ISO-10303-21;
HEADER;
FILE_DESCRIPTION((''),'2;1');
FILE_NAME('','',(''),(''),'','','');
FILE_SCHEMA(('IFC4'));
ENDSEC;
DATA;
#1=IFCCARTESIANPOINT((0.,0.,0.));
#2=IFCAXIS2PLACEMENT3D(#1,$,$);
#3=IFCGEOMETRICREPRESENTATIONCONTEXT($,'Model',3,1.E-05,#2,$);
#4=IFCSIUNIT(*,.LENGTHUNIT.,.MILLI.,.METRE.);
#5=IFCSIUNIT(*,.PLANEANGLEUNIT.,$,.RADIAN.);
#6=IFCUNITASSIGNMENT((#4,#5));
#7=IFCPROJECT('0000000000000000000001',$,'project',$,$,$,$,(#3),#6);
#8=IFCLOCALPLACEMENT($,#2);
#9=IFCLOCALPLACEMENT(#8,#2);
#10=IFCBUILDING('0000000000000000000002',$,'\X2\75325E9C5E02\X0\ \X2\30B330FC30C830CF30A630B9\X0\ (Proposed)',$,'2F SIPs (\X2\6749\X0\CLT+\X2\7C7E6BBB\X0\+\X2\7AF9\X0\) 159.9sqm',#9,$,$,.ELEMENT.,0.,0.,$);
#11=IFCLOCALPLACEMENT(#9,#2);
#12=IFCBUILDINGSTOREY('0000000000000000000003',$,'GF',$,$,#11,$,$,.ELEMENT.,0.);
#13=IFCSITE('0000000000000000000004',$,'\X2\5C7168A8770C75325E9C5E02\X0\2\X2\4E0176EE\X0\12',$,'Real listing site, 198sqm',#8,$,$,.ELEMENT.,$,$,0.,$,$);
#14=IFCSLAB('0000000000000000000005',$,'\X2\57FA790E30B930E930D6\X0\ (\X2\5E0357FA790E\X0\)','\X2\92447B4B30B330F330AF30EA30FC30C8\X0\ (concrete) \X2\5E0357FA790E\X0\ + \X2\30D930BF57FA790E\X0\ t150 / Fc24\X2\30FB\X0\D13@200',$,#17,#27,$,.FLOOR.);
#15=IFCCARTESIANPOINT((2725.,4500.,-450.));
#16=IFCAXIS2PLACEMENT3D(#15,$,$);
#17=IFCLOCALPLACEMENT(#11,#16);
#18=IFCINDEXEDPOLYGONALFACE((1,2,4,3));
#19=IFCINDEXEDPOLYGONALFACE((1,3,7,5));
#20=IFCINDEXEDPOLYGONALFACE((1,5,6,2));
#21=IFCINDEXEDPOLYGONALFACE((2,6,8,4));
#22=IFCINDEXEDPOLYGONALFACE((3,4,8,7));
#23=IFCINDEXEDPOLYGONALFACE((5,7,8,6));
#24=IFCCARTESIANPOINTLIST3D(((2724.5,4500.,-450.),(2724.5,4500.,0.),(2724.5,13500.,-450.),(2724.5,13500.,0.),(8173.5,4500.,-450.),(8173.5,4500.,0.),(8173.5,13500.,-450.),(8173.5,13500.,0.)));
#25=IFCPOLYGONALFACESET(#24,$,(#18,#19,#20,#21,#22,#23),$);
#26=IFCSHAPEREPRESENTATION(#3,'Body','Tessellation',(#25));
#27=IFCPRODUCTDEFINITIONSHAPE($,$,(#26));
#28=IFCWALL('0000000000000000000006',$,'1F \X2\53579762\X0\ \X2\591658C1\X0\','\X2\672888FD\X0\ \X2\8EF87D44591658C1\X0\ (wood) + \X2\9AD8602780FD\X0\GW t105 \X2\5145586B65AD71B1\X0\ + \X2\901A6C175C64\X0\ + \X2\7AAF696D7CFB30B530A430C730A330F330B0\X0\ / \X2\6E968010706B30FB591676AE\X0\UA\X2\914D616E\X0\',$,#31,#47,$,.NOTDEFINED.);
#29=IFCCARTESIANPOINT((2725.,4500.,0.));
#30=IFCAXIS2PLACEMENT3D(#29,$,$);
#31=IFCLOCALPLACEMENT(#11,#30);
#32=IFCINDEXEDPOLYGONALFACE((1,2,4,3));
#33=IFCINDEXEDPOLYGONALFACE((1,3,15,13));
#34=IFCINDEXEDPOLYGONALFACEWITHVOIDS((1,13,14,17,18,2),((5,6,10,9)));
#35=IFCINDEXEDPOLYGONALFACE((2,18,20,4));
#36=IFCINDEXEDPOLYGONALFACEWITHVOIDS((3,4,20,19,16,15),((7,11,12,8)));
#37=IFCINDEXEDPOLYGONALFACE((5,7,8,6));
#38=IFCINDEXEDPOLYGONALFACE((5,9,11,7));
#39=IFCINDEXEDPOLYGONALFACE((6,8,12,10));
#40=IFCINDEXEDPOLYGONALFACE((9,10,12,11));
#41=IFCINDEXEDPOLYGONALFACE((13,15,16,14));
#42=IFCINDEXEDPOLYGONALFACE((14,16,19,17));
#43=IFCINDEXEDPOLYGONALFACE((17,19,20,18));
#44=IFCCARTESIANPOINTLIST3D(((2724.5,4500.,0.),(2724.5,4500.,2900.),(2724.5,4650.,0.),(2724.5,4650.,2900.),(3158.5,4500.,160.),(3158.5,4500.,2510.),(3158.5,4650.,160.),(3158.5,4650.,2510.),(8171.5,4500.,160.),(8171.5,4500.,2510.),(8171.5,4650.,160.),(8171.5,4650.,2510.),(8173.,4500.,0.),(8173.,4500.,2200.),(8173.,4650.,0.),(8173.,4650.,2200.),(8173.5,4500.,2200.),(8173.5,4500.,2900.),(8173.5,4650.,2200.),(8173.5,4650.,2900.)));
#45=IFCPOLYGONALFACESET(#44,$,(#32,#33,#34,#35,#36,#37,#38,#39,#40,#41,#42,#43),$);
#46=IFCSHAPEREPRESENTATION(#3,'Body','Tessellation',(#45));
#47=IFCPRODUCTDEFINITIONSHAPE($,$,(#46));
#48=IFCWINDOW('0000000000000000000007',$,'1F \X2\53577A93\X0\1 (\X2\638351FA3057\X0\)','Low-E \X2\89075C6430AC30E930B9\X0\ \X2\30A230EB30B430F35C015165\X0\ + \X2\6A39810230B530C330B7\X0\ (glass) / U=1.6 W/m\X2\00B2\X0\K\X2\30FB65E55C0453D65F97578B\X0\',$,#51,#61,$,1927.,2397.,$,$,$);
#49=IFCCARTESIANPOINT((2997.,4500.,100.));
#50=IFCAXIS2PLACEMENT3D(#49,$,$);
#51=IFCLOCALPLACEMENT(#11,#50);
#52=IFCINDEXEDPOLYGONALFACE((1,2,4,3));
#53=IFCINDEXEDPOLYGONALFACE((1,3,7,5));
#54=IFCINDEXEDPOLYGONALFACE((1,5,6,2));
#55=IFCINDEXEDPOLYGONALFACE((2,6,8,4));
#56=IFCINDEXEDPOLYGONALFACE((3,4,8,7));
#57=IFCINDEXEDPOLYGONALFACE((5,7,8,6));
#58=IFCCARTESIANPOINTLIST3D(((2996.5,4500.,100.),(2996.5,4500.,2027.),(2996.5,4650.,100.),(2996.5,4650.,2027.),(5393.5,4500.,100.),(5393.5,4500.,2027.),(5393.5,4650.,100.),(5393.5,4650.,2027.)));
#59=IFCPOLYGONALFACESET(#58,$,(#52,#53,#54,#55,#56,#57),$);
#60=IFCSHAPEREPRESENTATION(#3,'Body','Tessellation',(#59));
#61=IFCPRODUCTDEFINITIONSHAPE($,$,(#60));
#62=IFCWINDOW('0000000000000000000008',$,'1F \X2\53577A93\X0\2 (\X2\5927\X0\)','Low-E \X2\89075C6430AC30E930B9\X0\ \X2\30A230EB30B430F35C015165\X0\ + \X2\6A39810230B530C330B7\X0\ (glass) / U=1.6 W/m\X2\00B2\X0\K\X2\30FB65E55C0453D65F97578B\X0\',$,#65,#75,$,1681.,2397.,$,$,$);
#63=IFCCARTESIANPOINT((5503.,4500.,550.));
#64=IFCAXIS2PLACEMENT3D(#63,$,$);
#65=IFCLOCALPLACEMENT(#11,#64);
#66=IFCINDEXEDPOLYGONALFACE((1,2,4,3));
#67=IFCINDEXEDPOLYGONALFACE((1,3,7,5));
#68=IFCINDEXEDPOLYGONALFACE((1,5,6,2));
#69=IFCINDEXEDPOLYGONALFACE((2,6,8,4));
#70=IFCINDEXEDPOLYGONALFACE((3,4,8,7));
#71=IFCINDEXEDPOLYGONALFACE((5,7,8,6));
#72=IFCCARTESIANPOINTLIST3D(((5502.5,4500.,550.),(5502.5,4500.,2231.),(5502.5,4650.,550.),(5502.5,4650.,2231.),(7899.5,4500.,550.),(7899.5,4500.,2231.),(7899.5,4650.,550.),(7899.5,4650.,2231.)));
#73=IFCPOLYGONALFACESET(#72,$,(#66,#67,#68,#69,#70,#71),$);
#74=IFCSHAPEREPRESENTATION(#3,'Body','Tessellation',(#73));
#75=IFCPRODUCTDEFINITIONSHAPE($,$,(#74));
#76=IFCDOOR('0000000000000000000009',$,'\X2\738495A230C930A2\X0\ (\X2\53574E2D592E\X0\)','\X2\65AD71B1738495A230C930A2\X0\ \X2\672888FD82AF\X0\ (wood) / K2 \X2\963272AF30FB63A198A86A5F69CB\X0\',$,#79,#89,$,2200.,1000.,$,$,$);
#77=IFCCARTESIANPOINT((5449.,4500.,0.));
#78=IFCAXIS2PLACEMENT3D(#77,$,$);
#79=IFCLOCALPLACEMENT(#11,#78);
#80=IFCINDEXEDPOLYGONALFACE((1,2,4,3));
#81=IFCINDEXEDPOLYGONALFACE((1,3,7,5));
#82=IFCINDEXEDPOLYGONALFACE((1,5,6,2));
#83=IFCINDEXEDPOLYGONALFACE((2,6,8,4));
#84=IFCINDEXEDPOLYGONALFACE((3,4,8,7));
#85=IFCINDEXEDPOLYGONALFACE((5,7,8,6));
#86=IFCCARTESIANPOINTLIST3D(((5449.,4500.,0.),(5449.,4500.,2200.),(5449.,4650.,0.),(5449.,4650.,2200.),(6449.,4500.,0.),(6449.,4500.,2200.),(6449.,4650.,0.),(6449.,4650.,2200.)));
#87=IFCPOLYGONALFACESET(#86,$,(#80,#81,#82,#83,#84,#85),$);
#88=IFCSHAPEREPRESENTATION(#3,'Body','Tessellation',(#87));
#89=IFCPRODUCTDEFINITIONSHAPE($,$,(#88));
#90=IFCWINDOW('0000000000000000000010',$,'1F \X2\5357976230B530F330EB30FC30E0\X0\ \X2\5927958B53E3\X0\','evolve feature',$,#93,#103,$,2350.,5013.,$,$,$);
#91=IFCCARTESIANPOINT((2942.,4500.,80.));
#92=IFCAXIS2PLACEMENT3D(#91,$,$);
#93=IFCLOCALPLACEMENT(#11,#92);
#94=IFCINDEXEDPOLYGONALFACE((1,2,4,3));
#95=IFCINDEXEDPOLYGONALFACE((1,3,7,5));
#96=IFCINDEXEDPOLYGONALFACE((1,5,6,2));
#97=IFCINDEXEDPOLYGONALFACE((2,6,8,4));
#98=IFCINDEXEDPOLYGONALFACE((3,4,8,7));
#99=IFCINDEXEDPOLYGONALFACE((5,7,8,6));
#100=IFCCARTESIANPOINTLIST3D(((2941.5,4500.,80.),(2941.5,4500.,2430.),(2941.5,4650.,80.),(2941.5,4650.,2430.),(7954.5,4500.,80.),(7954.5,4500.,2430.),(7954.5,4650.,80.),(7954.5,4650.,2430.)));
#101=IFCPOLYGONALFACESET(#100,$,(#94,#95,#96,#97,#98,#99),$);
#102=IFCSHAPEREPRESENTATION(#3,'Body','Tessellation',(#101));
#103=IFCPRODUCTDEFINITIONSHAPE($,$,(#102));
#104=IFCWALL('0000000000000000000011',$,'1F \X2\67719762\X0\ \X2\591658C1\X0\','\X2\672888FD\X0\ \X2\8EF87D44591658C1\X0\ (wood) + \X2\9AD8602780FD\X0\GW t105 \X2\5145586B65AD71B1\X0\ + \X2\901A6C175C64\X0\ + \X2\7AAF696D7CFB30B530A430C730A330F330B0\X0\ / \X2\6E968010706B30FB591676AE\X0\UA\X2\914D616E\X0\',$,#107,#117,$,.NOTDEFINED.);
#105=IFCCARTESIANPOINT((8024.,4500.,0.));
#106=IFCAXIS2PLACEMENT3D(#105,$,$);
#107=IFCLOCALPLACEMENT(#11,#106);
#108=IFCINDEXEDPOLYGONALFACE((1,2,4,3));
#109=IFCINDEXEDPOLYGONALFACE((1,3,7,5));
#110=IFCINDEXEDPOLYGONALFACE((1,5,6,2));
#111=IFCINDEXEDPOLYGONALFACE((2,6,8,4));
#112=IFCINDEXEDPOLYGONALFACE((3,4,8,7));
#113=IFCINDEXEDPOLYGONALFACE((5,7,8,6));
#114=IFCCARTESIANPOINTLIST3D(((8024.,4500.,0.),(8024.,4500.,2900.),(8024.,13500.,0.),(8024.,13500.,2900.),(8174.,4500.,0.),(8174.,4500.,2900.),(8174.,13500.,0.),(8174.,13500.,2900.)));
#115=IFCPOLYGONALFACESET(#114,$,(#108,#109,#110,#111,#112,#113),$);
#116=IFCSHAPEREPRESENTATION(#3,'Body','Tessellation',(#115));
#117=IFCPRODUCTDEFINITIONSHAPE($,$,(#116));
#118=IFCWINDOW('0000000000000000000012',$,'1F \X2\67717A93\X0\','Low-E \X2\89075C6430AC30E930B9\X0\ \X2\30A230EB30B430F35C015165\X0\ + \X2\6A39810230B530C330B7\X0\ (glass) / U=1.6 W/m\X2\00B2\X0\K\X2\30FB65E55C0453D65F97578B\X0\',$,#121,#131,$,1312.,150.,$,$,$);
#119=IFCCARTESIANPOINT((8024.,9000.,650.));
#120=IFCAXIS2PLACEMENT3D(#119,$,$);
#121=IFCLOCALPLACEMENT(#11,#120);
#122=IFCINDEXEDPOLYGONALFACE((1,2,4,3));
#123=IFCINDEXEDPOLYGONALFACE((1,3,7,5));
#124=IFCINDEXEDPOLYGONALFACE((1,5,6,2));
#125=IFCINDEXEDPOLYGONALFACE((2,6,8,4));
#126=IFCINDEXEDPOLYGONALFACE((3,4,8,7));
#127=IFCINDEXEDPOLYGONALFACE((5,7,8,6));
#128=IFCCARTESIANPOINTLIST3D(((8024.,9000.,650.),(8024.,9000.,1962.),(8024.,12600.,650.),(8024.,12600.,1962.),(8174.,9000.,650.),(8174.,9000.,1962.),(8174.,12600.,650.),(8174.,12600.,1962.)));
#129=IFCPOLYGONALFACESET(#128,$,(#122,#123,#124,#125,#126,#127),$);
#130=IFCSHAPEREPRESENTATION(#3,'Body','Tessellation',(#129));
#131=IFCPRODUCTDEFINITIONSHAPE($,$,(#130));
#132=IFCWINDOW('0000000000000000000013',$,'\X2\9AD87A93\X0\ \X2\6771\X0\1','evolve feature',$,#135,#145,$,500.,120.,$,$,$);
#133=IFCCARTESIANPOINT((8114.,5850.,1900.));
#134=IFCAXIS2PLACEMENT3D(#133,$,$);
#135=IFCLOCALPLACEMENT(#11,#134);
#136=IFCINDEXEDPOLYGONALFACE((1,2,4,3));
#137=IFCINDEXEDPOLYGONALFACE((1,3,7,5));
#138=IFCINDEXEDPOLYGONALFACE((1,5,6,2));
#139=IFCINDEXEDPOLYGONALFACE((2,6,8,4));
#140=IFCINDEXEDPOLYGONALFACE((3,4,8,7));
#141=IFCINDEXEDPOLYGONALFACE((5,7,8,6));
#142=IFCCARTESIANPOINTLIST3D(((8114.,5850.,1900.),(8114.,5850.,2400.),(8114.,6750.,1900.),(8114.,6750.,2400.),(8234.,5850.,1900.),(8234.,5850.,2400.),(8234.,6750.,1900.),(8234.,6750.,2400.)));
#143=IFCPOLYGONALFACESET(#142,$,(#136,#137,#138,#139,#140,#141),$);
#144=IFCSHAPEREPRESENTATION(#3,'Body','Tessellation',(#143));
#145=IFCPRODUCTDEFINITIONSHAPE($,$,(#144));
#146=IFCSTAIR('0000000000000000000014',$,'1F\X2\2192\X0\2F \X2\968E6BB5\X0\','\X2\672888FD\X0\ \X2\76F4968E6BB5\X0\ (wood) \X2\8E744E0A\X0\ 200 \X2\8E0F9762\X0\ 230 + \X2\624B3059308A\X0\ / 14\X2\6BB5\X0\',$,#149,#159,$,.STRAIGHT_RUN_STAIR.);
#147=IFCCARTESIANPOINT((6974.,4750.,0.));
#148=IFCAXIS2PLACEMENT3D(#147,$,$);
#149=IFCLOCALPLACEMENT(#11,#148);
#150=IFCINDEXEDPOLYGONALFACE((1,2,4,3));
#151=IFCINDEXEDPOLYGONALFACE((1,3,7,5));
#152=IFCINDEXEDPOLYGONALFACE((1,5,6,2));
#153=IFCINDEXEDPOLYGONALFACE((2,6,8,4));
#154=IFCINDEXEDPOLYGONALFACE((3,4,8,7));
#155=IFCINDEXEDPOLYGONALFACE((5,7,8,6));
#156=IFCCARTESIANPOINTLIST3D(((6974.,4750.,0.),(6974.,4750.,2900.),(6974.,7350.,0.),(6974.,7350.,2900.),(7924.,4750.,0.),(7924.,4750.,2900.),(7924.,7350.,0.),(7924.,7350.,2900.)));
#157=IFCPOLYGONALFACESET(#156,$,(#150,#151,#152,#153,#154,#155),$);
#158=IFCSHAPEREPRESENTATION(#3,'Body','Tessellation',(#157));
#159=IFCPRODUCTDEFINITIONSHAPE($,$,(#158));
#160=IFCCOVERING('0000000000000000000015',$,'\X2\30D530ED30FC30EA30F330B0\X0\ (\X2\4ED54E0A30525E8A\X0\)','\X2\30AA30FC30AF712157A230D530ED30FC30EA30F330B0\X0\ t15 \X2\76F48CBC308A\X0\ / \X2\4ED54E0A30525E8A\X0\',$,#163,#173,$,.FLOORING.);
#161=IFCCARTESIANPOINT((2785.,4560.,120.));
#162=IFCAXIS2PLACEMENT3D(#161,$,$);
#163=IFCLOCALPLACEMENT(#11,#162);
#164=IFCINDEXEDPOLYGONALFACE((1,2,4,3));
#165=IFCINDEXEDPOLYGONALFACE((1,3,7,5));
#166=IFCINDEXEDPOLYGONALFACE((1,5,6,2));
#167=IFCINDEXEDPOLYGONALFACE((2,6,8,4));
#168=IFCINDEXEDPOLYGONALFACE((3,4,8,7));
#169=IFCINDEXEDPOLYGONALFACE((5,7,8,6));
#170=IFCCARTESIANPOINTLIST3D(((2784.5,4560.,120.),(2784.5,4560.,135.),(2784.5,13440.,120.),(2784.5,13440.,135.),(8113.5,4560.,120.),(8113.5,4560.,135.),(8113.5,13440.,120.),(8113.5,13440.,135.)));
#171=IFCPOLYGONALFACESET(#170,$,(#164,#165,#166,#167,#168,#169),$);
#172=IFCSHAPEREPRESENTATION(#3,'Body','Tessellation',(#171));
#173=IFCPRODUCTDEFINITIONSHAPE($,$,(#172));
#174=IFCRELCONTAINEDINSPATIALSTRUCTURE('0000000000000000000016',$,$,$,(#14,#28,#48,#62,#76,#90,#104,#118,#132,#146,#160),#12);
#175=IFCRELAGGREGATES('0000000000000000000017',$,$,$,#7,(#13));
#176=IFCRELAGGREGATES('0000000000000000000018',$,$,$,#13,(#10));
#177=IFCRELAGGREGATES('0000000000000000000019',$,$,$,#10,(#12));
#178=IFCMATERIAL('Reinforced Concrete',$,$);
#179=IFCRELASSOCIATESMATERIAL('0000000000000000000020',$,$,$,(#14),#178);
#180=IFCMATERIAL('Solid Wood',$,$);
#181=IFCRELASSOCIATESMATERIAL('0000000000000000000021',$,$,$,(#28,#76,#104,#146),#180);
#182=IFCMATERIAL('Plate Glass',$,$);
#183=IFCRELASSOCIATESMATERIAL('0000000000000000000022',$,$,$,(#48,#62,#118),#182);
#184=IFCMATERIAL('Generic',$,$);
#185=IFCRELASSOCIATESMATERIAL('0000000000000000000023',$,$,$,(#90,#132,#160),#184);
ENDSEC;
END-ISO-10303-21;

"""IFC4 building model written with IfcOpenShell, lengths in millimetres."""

from ifc_helpers import new_model, si_unit, frame, frame_2d, origin, place, context, project, spatial, rectangle, extrude, material, element, fill, save


model = new_model("IFC4")

# Units and contexts
model_context = context("Model", 3, precision=1e-05, world=origin())
ifc_project = project(units=[si_unit("LENGTHUNIT", "METRE", prefix="MILLI"), si_unit("PLANEANGLEUNIT", "RADIAN")], contexts=[model_context])

# Site, building, storey
site_placement = place(None, origin())
site = spatial("IfcSite", under=ifc_project, at=site_placement, Name="山梨県甲府市2丁目12", ObjectType="Real listing site, 198sqm", CompositionType="ELEMENT", RefElevation=0.0)
building_placement = place(site_placement, origin())
building = spatial("IfcBuilding", under=site, at=building_placement, Name="甲府市 コートハウス (Proposed)", ObjectType="2F SIPs (杉CLT+籾殻+竹) 159.9sqm", CompositionType="ELEMENT", ElevationOfRefHeight=0.0, ElevationOfTerrain=0.0)
storey_placement = place(building_placement, origin())
storey = spatial("IfcBuildingStorey", under=building, at=storey_placement, Name="GF", CompositionType="ELEMENT", Elevation=0.0)

# Slab
ifc_material_1 = material(Name="Reinforced Concrete")
slab_1_placement = place(storey_placement, frame((2725.0, 4500.0, -450.0)))
element("IfcSlab", 1, at=slab_1_placement, inside=storey, material=ifc_material_1, Name="基礎スラブ (布基礎)", Description="鉄筋コンクリート (concrete) 布基礎 + ベタ基礎 t150 / Fc24・D13@200", PredefinedType="FLOOR", context=model_context, shape_type="SweptSolid", body=[
    extrude(rectangle(XDim=5449.0, YDim=9000.0, at=frame_2d((2724.0, 4500.0))), frame((2725.0, 4500.0, -450.0)), (0.0, 0.0, 1.0), 450.0),
])
ifc_material_2 = material(Name="Solid Wood")
ifc_material_3 = material(Name="Generic")

# Wall, openings, windows, door
wall_1_placement = place(storey_placement, frame((2725.0, 4500.0, 0.0)))
wall_1 = element("IfcWall", 2, at=wall_1_placement, inside=storey, material=ifc_material_2, Name="1F 南面 外壁", Description="木製 軸組外壁 (wood) + 高性能GW t105 充填断熱 + 通気層 + 窯業系サイディング / 準耐火・外皮UA配慮", PredefinedType="NOTDEFINED", context=model_context, shape_type="SweptSolid", body=[
    extrude(rectangle(XDim=5449.0, YDim=150.0, at=frame_2d((2724.0, 75.0))), frame((2725.0, 4500.0, 0.0)), (0.0, 0.0, 1.0), 2900.0),
])
opening_1_placement = place(storey_placement, frame((2997.0, 4500.0, 100.0)))
opening_1 = element("IfcOpeningElement", 3, at=opening_1_placement, cuts=wall_1, PredefinedType="NOTDEFINED", context=model_context, shape_type="SweptSolid", body=[
    extrude(rectangle(XDim=2397.0, YDim=150.0, at=frame_2d((1198.0, 75.0))), frame((2997.0, 4500.0, 100.0)), (0.0, 0.0, 1.0), 1927.0),
])
opening_2_placement = place(storey_placement, frame((5503.0, 4500.0, 550.0)))
opening_2 = element("IfcOpeningElement", 4, at=opening_2_placement, cuts=wall_1, PredefinedType="NOTDEFINED", context=model_context, shape_type="SweptSolid", body=[
    extrude(rectangle(XDim=2397.0, YDim=150.0, at=frame_2d((1198.0, 75.0))), frame((5503.0, 4500.0, 550.0)), (0.0, 0.0, 1.0), 1681.0),
])
opening_3_placement = place(storey_placement, frame((5449.0, 4500.0, 0.0)))
opening_3 = element("IfcOpeningElement", 5, at=opening_3_placement, cuts=wall_1, PredefinedType="NOTDEFINED", context=model_context, shape_type="SweptSolid", body=[
    extrude(rectangle(XDim=1000.0, YDim=150.0, at=frame_2d((500.0, 75.0))), frame((5449.0, 4500.0, 0.0)), (0.0, 0.0, 1.0), 2200.0),
])
opening_4_placement = place(storey_placement, frame((2942.0, 4500.0, 80.0)))
opening_4 = element("IfcOpeningElement", 6, at=opening_4_placement, cuts=wall_1, PredefinedType="NOTDEFINED", context=model_context, shape_type="SweptSolid", body=[
    extrude(rectangle(XDim=5013.0, YDim=150.0, at=frame_2d((2506.0, 75.0))), frame((2942.0, 4500.0, 80.0)), (0.0, 0.0, 1.0), 2350.0),
])
ifc_material_4 = material(Name="Plate Glass")
window_1_placement = place(storey_placement, frame((2997.0, 4500.0, 100.0)))
window_1 = element("IfcWindow", 7, at=window_1_placement, inside=storey, material=ifc_material_4, Name="1F 南窓1 (掃出し)", Description="Low-E 複層ガラス アルゴン封入 + 樹脂サッシ (glass) / U=1.6 W/m²K・日射取得型", OverallHeight=1927.0, OverallWidth=2397.0, context=model_context, shape_type="SweptSolid", body=[
    extrude(rectangle(XDim=2397.0, YDim=150.0, at=frame_2d((1198.0, 75.0))), frame((2997.0, 4500.0, 100.0)), (0.0, 0.0, 1.0), 1927.0),
])
fill(opening_1, window_1)
window_2_placement = place(storey_placement, frame((5503.0, 4500.0, 550.0)))
window_2 = element("IfcWindow", 8, at=window_2_placement, inside=storey, material=ifc_material_4, Name="1F 南窓2 (大)", Description="Low-E 複層ガラス アルゴン封入 + 樹脂サッシ (glass) / U=1.6 W/m²K・日射取得型", OverallHeight=1681.0, OverallWidth=2397.0, context=model_context, shape_type="SweptSolid", body=[
    extrude(rectangle(XDim=2397.0, YDim=150.0, at=frame_2d((1198.0, 75.0))), frame((5503.0, 4500.0, 550.0)), (0.0, 0.0, 1.0), 1681.0),
])
fill(opening_2, window_2)
door_placement = place(storey_placement, frame((5449.0, 4500.0, 0.0)))
door = element("IfcDoor", 9, at=door_placement, inside=storey, material=ifc_material_2, Name="玄関ドア (南中央)", Description="断熱玄関ドア 木製芯 (wood) / K2 防犯・採風機構", OverallHeight=2200.0, OverallWidth=1000.0, context=model_context, shape_type="SweptSolid", body=[
    extrude(rectangle(XDim=1000.0, YDim=150.0, at=frame_2d((500.0, 75.0))), frame((5449.0, 4500.0, 0.0)), (0.0, 0.0, 1.0), 2200.0),
])
fill(opening_3, door)
window_3_placement = place(storey_placement, frame((2942.0, 4500.0, 80.0)))
window_3 = element("IfcWindow", 10, at=window_3_placement, inside=storey, material=ifc_material_3, Name="1F 南面サンルーム 大開口", Description="evolve feature", OverallHeight=2350.0, OverallWidth=5013.0, context=model_context, shape_type="SweptSolid", body=[
    extrude(rectangle(XDim=5013.0, YDim=150.0, at=frame_2d((2506.0, 75.0))), frame((2942.0, 4500.0, 80.0)), (0.0, 0.0, 1.0), 2350.0),
])
fill(opening_4, window_3)

# Wall, openings, windows
wall_2_placement = place(storey_placement, frame((8024.0, 4500.0, 0.0)))
wall_2 = element("IfcWall", 11, at=wall_2_placement, inside=storey, material=ifc_material_2, Name="1F 東面 外壁", Description="木製 軸組外壁 (wood) + 高性能GW t105 充填断熱 + 通気層 + 窯業系サイディング / 準耐火・外皮UA配慮", PredefinedType="NOTDEFINED", context=model_context, shape_type="SweptSolid", body=[
    extrude(rectangle(XDim=150.0, YDim=9000.0, at=frame_2d((75.0, 4500.0))), frame((8024.0, 4500.0, 0.0)), (0.0, 0.0, 1.0), 2900.0),
])
opening_5_placement = place(storey_placement, frame((8024.0, 9000.0, 650.0)))
opening_5 = element("IfcOpeningElement", 12, at=opening_5_placement, cuts=wall_2, PredefinedType="NOTDEFINED", context=model_context, shape_type="SweptSolid", body=[
    extrude(rectangle(XDim=150.0, YDim=3600.0, at=frame_2d((75.0, 1800.0))), frame((8024.0, 9000.0, 650.0)), (0.0, 0.0, 1.0), 1312.0),
])
opening_6_placement = place(storey_placement, frame((8114.0, 5850.0, 1900.0)))
opening_6 = element("IfcOpeningElement", 13, at=opening_6_placement, cuts=wall_2, PredefinedType="NOTDEFINED", context=model_context, shape_type="SweptSolid", body=[
    extrude(rectangle(XDim=120.0, YDim=900.0, at=frame_2d((60.0, 450.0))), frame((8114.0, 5850.0, 1900.0)), (0.0, 0.0, 1.0), 500.0),
])
window_4_placement = place(storey_placement, frame((8024.0, 9000.0, 650.0)))
window_4 = element("IfcWindow", 14, at=window_4_placement, inside=storey, material=ifc_material_4, Name="1F 東窓", Description="Low-E 複層ガラス アルゴン封入 + 樹脂サッシ (glass) / U=1.6 W/m²K・日射取得型", OverallHeight=1312.0, OverallWidth=150.0, context=model_context, shape_type="SweptSolid", body=[
    extrude(rectangle(XDim=150.0, YDim=3600.0, at=frame_2d((75.0, 1800.0))), frame((8024.0, 9000.0, 650.0)), (0.0, 0.0, 1.0), 1312.0),
])
fill(opening_5, window_4)
window_5_placement = place(storey_placement, frame((8114.0, 5850.0, 1900.0)))
window_5 = element("IfcWindow", 15, at=window_5_placement, inside=storey, material=ifc_material_3, Name="高窓 東1", Description="evolve feature", OverallHeight=500.0, OverallWidth=120.0, context=model_context, shape_type="SweptSolid", body=[
    extrude(rectangle(XDim=120.0, YDim=900.0, at=frame_2d((60.0, 450.0))), frame((8114.0, 5850.0, 1900.0)), (0.0, 0.0, 1.0), 500.0),
])
fill(opening_6, window_5)

# Stair
stair_placement = place(storey_placement, frame((6974.0, 4750.0, 0.0)))
element("IfcStair", 16, at=stair_placement, inside=storey, material=ifc_material_2, Name="1F→2F 階段", Description="木製 直階段 (wood) 蹴上 200 踏面 230 + 手すり / 14段", PredefinedType="STRAIGHT_RUN_STAIR", context=model_context, shape_type="SweptSolid", body=[
    extrude(rectangle(XDim=950.0, YDim=2600.0, at=frame_2d((475.0, 1300.0))), frame((6974.0, 4750.0, 0.0)), (0.0, 0.0, 1.0), 2900.0),
])

# Covering
covering_placement = place(storey_placement, frame((2785.0, 4560.0, 120.0)))
element("IfcCovering", 17, at=covering_placement, inside=storey, material=ifc_material_3, Name="フローリング (仕上げ床)", Description="オーク無垢フローリング t15 直貼り / 仕上げ床", PredefinedType="FLOORING", context=model_context, shape_type="SweptSolid", body=[
    extrude(rectangle(XDim=5329.0, YDim=8880.0, at=frame_2d((2664.0, 4440.0))), frame((2785.0, 4560.0, 120.0)), (0.0, 0.0, 1.0), 15.0),
])

save(model, "model.ifc")
